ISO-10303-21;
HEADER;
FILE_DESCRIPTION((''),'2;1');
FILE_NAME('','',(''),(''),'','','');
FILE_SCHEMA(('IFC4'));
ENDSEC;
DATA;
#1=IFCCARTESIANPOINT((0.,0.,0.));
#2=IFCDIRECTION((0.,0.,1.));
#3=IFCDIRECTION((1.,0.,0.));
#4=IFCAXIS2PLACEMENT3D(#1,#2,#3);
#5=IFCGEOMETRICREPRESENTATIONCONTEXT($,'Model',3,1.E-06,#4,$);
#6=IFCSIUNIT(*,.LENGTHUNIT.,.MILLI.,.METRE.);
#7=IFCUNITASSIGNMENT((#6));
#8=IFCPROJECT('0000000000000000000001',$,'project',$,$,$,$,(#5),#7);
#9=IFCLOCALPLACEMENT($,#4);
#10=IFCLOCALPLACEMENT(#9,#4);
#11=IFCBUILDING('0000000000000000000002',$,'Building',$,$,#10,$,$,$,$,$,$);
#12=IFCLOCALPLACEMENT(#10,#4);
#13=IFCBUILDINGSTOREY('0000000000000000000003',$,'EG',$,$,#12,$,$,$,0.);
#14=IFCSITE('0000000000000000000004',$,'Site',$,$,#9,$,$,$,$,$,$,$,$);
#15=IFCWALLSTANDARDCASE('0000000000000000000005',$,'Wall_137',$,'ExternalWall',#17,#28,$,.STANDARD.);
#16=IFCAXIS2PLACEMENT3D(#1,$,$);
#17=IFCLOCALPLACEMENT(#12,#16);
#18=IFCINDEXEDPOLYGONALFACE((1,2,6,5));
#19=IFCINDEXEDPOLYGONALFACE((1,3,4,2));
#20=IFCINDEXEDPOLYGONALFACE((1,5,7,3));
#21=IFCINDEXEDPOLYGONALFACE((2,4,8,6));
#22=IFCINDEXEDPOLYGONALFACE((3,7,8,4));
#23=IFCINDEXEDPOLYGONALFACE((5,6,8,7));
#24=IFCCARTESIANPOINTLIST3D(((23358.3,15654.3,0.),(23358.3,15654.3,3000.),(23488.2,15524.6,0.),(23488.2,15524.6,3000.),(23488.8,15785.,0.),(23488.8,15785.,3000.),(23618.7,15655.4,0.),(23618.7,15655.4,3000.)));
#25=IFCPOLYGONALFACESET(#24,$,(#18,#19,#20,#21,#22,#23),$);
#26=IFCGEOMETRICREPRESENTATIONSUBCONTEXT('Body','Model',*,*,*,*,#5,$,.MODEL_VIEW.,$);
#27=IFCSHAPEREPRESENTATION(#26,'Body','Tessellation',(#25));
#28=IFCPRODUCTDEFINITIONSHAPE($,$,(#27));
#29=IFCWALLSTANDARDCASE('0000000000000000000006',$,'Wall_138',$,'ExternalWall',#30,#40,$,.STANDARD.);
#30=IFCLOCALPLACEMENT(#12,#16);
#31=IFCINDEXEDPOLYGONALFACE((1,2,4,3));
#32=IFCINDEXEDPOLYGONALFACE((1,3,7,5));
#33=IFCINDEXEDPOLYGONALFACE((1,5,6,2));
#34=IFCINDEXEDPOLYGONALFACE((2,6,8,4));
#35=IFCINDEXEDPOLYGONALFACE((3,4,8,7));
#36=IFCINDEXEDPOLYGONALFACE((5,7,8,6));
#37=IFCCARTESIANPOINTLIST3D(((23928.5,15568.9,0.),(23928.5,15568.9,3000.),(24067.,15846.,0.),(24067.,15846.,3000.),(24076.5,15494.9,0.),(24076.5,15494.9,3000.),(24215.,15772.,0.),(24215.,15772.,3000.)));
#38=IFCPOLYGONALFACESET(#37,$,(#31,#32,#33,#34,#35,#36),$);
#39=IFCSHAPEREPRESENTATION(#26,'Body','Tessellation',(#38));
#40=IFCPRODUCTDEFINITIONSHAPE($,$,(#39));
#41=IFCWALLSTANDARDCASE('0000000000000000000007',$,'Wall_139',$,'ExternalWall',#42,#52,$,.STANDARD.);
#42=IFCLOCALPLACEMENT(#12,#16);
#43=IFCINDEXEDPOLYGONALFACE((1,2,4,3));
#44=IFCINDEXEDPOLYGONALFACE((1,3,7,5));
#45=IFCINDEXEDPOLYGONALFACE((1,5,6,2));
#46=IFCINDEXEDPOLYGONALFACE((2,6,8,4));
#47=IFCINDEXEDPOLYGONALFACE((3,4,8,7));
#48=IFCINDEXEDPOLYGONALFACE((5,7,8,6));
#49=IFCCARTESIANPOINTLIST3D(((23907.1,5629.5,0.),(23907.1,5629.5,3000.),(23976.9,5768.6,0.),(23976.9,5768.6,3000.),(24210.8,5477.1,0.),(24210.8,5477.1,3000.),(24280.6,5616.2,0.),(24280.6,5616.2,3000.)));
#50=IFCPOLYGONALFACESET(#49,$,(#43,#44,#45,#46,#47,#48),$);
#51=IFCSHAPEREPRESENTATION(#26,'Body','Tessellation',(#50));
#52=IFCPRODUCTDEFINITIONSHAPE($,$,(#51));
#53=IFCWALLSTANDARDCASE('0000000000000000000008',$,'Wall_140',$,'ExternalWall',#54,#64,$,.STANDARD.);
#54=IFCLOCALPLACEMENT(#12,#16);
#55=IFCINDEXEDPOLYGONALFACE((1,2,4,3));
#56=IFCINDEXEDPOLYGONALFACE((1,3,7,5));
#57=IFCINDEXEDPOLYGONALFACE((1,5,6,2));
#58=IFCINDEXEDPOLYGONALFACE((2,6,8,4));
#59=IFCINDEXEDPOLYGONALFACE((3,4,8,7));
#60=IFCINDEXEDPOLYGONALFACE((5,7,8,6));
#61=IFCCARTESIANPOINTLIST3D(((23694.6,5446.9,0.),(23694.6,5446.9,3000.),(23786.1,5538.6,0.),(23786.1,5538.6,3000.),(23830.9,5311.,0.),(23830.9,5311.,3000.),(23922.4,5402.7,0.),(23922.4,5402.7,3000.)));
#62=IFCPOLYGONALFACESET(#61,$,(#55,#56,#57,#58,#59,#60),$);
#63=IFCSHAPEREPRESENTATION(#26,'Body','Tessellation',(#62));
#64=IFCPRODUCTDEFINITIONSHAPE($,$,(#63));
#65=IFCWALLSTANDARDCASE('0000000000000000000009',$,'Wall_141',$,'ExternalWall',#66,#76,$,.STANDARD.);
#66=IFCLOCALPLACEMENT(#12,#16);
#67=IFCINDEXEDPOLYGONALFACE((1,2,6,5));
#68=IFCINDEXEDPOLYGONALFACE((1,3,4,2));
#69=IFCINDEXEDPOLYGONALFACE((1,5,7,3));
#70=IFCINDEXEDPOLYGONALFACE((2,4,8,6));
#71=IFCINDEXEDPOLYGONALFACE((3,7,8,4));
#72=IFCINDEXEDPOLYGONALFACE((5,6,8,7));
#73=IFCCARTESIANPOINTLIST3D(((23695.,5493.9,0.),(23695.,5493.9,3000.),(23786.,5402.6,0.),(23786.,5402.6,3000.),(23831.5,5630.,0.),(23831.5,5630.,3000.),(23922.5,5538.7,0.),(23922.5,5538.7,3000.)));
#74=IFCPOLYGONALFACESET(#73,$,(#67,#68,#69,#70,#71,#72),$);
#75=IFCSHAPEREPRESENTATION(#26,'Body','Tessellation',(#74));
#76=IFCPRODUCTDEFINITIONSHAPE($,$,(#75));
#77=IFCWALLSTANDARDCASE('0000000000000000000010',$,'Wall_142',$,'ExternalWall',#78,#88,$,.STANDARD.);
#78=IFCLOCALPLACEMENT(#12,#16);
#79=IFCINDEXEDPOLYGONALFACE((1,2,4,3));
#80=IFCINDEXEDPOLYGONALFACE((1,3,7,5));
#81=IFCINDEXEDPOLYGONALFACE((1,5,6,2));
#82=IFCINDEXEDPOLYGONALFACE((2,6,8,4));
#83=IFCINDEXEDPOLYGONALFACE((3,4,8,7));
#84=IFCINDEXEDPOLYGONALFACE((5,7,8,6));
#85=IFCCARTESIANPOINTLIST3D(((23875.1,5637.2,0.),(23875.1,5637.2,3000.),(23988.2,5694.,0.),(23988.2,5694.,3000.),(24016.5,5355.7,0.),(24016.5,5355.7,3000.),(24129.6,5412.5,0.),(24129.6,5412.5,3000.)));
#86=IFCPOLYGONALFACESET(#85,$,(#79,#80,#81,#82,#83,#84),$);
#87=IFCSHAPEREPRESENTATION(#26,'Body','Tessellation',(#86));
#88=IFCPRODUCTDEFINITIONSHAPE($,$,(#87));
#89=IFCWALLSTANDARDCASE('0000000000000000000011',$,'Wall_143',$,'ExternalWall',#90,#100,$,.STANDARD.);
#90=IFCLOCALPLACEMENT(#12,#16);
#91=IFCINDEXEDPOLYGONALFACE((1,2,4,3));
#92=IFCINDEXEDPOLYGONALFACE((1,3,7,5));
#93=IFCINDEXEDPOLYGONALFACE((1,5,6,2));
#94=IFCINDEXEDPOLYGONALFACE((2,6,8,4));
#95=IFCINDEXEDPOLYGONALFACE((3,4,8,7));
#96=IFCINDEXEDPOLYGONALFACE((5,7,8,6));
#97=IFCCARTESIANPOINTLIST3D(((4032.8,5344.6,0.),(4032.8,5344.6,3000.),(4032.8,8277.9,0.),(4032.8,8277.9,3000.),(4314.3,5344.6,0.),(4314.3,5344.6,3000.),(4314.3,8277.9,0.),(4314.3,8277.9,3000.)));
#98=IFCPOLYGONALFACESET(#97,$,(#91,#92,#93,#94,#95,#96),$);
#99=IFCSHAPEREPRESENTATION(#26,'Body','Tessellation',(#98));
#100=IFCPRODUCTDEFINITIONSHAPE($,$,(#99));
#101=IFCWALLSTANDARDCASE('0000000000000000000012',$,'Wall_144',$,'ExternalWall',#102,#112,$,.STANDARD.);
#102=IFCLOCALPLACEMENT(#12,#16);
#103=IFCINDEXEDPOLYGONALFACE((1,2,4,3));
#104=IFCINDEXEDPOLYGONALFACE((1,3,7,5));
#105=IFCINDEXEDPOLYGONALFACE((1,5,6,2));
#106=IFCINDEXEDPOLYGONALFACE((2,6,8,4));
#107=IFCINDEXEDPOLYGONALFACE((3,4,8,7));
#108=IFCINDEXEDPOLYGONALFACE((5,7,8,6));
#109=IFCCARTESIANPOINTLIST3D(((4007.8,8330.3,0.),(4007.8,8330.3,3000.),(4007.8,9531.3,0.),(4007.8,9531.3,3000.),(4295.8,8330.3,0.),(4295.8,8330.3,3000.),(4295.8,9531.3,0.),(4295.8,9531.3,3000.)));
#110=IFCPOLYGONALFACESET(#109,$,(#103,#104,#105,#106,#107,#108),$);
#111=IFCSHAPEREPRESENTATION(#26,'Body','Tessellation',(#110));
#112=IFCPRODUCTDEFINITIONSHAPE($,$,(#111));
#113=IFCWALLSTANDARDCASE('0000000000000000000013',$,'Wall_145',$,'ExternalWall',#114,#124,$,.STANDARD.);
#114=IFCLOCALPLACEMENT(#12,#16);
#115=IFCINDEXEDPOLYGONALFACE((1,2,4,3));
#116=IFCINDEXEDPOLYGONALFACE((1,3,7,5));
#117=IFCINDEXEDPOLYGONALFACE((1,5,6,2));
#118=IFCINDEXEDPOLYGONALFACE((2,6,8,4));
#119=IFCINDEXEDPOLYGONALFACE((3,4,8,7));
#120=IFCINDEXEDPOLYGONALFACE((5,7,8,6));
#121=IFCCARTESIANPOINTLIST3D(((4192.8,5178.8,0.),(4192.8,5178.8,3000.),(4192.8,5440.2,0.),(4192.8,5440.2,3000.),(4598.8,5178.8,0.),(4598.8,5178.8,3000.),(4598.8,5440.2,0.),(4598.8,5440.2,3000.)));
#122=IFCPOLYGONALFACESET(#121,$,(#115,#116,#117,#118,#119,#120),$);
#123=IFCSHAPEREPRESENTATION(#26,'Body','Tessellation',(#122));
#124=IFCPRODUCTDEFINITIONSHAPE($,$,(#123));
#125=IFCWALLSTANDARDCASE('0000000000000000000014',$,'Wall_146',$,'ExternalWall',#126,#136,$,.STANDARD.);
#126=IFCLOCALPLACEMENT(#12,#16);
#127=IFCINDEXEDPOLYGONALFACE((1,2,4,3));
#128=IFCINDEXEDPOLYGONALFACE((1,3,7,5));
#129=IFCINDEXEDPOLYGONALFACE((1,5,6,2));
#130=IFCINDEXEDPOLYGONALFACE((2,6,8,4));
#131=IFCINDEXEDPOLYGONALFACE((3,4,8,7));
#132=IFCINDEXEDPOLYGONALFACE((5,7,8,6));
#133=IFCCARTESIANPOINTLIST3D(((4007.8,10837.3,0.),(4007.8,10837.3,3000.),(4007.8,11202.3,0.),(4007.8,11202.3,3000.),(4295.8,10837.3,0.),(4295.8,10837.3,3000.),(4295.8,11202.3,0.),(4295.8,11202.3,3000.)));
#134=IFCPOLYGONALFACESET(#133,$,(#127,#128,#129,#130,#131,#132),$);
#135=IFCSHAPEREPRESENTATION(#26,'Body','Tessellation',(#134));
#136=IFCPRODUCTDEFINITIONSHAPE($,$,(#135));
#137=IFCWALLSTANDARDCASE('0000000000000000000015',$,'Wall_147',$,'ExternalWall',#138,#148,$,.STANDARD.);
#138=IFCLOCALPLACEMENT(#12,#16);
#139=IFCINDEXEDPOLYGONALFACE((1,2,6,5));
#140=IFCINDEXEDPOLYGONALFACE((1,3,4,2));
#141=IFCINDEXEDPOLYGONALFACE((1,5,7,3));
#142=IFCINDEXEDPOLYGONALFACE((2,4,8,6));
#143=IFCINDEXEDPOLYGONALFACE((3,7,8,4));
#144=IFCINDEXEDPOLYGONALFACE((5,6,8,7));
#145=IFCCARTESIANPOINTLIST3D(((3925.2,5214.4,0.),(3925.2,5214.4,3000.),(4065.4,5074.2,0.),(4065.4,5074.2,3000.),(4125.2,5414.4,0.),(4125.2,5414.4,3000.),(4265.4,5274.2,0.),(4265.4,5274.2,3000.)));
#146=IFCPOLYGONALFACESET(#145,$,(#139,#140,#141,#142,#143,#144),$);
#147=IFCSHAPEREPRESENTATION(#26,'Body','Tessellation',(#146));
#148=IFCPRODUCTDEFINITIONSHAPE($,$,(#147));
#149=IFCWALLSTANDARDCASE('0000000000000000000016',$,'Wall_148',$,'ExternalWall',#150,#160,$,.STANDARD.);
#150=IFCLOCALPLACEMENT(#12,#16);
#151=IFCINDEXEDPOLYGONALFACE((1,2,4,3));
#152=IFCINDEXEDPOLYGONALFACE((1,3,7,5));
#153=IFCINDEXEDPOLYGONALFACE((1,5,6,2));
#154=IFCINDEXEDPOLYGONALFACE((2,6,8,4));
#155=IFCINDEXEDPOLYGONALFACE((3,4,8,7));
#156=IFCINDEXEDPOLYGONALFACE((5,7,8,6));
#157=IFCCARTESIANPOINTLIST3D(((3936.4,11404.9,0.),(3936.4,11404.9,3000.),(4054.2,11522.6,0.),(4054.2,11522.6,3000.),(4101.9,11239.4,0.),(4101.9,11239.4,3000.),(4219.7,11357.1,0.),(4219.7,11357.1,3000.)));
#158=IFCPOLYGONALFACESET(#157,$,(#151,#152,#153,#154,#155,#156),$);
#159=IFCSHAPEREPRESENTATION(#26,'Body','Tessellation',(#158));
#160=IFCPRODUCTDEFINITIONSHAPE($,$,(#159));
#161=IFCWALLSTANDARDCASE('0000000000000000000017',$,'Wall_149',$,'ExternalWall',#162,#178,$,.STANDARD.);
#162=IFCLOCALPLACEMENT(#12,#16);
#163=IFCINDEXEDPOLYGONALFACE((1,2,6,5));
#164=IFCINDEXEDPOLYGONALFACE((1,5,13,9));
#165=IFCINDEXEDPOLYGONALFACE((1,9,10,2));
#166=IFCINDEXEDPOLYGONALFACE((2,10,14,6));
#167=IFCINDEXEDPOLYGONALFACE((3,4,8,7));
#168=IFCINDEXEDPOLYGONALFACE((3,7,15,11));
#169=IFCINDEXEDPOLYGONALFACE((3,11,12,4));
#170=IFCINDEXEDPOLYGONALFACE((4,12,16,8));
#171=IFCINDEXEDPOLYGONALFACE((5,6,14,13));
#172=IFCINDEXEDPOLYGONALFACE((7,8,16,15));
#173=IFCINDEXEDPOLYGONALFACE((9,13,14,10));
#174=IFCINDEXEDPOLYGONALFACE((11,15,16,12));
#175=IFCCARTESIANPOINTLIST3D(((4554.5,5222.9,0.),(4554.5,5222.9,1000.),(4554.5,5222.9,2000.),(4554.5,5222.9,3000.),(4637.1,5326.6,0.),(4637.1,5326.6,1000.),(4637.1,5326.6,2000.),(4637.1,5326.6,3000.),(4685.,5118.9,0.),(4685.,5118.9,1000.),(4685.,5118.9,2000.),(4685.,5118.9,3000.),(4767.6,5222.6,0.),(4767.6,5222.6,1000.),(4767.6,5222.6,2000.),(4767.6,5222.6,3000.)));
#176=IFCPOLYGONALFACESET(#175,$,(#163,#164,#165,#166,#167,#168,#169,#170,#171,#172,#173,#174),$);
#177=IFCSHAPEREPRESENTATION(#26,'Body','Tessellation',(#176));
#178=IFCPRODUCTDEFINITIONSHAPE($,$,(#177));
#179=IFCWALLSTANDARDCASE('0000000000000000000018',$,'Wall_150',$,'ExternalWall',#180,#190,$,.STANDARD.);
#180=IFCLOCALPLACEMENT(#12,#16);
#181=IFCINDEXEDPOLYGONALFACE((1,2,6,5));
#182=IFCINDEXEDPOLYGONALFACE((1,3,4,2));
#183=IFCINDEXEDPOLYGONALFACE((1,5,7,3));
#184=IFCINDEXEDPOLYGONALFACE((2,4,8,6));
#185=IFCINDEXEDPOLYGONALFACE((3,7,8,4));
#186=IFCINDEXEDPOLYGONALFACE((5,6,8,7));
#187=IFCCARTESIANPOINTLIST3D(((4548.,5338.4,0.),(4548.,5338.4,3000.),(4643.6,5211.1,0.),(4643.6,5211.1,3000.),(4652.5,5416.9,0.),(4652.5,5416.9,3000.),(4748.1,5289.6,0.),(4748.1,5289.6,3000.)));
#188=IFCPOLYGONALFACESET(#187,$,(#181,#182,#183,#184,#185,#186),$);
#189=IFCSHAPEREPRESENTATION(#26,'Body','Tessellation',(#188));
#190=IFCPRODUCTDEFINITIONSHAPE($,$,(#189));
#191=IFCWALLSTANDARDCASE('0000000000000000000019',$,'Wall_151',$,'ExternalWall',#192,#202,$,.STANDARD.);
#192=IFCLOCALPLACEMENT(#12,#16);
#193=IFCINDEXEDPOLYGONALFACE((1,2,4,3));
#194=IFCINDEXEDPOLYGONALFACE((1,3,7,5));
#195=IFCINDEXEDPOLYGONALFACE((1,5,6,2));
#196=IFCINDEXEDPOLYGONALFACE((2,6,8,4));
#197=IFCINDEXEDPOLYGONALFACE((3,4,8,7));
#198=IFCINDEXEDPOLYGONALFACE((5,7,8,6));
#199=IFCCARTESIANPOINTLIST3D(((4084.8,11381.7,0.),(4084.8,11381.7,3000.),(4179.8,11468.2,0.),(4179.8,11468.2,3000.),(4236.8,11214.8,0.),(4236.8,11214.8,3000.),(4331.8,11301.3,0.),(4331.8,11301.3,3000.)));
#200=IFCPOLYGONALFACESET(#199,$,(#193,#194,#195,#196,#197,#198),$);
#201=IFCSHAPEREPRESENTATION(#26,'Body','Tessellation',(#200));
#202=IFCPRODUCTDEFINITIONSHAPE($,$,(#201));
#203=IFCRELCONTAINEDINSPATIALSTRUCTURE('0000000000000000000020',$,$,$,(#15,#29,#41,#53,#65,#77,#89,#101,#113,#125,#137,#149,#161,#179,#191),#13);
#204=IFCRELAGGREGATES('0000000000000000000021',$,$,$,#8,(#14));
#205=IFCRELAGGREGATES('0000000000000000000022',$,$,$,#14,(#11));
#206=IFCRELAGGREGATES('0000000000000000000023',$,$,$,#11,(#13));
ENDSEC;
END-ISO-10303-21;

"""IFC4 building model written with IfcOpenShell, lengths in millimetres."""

from ifc_helpers import new_model, si_unit, frame, origin_with_axes, place, context, subcontext, project, spatial, rectangle, extrude, element, save


model = new_model("IFC4")

# Units and contexts
model_context = context("Model", 3, precision=1e-06, world=origin_with_axes())
body_context = subcontext(model_context, "Body", "Model", "MODEL_VIEW")
ifc_project = project(units=[si_unit("LENGTHUNIT", "METRE", prefix="MILLI")], contexts=[model_context])

# Site, building, storey
site_placement = place(None, origin_with_axes())
site = spatial("IfcSite", under=ifc_project, at=site_placement, Name="Site")
building_placement = place(site_placement, origin_with_axes())
building = spatial("IfcBuilding", under=site, at=building_placement, Name="Building")
storey_placement = place(building_placement, origin_with_axes())
storey = spatial("IfcBuildingStorey", under=building, at=storey_placement, Name="EG", Elevation=0.0)

# Walls
wall_1_placement = place(storey_placement, origin_with_axes())
element("IfcWallStandardCase", 1, at=wall_1_placement, inside=storey, Name="Wall_137", ObjectType="ExternalWall", PredefinedType="STANDARD", context=body_context, shape_type="SweptSolid", body=[
    extrude(rectangle(XDim=184.7, YDim=183.5), frame((23488.5, 15654.8, 0.0), z_axis=(0.0, 0.0, 1.0), x_axis=(-0.70643, -0.707783, 0.0)), (0.0, 0.0, 1.0), 3000.0),
])
wall_2_placement = place(storey_placement, origin_with_axes())
element("IfcWallStandardCase", 2, at=wall_2_placement, inside=storey, Name="Wall_138", ObjectType="ExternalWall", PredefinedType="STANDARD", context=body_context, shape_type="SweptSolid", body=[
    extrude(rectangle(XDim=165.5, YDim=309.9), frame((24071.8, 15670.4, 0.0), z_axis=(0.0, 0.0, 1.0), x_axis=(-0.894427, 0.447214, 0.0)), (0.0, 0.0, 1.0), 3000.0),
])
wall_3_placement = place(storey_placement, origin_with_axes())
element("IfcWallStandardCase", 3, at=wall_3_placement, inside=storey, Name="Wall_139", ObjectType="ExternalWall", PredefinedType="STANDARD", context=body_context, shape_type="SweptSolid", body=[
    extrude(rectangle(XDim=155.7, YDim=339.8), frame((24093.8, 5622.9, 0.0), z_axis=(0.0, 0.0, 1.0), x_axis=(-0.448498, -0.893784, 0.0)), (0.0, 0.0, 1.0), 3000.0),
])
wall_4_placement = place(storey_placement, origin_with_axes())
element("IfcWallStandardCase", 4, at=wall_4_placement, inside=storey, Name="Wall_140", ObjectType="ExternalWall", PredefinedType="STANDARD", context=body_context, shape_type="SweptSolid", body=[
    extrude(rectangle(XDim=129.6, YDim=192.4), frame((23808.5, 5424.8, 0.0), z_axis=(0.0, 0.0, 1.0), x_axis=(-0.706141, -0.708071, 0.0)), (0.0, 0.0, 1.0), 3000.0),
])
wall_5_placement = place(storey_placement, origin_with_axes())
element("IfcWallStandardCase", 5, at=wall_5_placement, inside=storey, Name="Wall_141", ObjectType="ExternalWall", PredefinedType="STANDARD", context=body_context, shape_type="SweptSolid", body=[
    extrude(rectangle(XDim=128.9, YDim=192.7), frame((23808.8, 5516.3, 0.0), z_axis=(0.0, 0.0, 1.0), x_axis=(-0.706136, 0.708076, 0.0)), (0.0, 0.0, 1.0), 3000.0),
])
wall_6_placement = place(storey_placement, origin_with_axes())
element("IfcWallStandardCase", 6, at=wall_6_placement, inside=storey, Name="Wall_142", ObjectType="ExternalWall", PredefinedType="STANDARD", context=body_context, shape_type="SweptSolid", body=[
    extrude(rectangle(XDim=126.6, YDim=315.1), frame((24002.3, 5524.9, 0.0), z_axis=(0.0, 0.0, 1.0), x_axis=(-0.893636, -0.448792, 0.0)), (0.0, 0.0, 1.0), 3000.0),
])
wall_7_placement = place(storey_placement, origin_with_axes())
element("IfcWallStandardCase", 7, at=wall_7_placement, inside=storey, Name="Wall_143", ObjectType="ExternalWall", PredefinedType="STANDARD", context=body_context, shape_type="SweptSolid", body=[
    extrude(rectangle(XDim=2933.3, YDim=281.4), frame((4173.5, 6811.3, 0.0), z_axis=(0.0, 0.0, 1.0), x_axis=(0.0, -1.0, 0.0)), (0.0, 0.0, 1.0), 3000.0),
])
wall_8_placement = place(storey_placement, origin_with_axes())
element("IfcWallStandardCase", 8, at=wall_8_placement, inside=storey, Name="Wall_144", ObjectType="ExternalWall", PredefinedType="STANDARD", context=body_context, shape_type="SweptSolid", body=[
    extrude(rectangle(XDim=1201.0, YDim=288.0), frame((4151.8, 8930.8, 0.0), z_axis=(0.0, 0.0, 1.0), x_axis=(0.0, -1.0, 0.0)), (0.0, 0.0, 1.0), 3000.0),
])
wall_9_placement = place(storey_placement, origin_with_axes())
element("IfcWallStandardCase", 9, at=wall_9_placement, inside=storey, Name="Wall_145", ObjectType="ExternalWall", PredefinedType="STANDARD", context=body_context, shape_type="SweptSolid", body=[
    extrude(rectangle(XDim=406.0, YDim=261.4), frame((4395.8, 5309.5, 0.0), z_axis=(0.0, 0.0, 1.0), x_axis=(1.0, 0.0, 0.0)), (0.0, 0.0, 1.0), 3000.0),
])
wall_10_placement = place(storey_placement, origin_with_axes())
element("IfcWallStandardCase", 10, at=wall_10_placement, inside=storey, Name="Wall_146", ObjectType="ExternalWall", PredefinedType="STANDARD", context=body_context, shape_type="SweptSolid", body=[
    extrude(rectangle(XDim=365.0, YDim=288.0), frame((4151.8, 11019.8, 0.0), z_axis=(0.0, 0.0, 1.0), x_axis=(0.0, 1.0, 0.0)), (0.0, 0.0, 1.0), 3000.0),
])
wall_11_placement = place(storey_placement, origin_with_axes())
element("IfcWallStandardCase", 11, at=wall_11_placement, inside=storey, Name="Wall_147", ObjectType="ExternalWall", PredefinedType="STANDARD", context=body_context, shape_type="SweptSolid", body=[
    extrude(rectangle(XDim=282.8, YDim=198.3), frame((4095.3, 5244.3, 0.0), z_axis=(0.0, 0.0, 1.0), x_axis=(-0.707107, -0.707107, 0.0)), (0.0, 0.0, 1.0), 3000.0),
])
wall_12_placement = place(storey_placement, origin_with_axes())
element("IfcWallStandardCase", 12, at=wall_12_placement, inside=storey, Name="Wall_148", ObjectType="ExternalWall", PredefinedType="STANDARD", context=body_context, shape_type="SweptSolid", body=[
    extrude(rectangle(XDim=234.1, YDim=166.5), frame((4078.0, 11381.0, 0.0), z_axis=(0.0, 0.0, 1.0), x_axis=(-0.707107, 0.707107, 0.0)), (0.0, 0.0, 1.0), 3000.0),
])

# Wall, opening
wall_13_placement = place(storey_placement, origin_with_axes())
wall_13 = element("IfcWallStandardCase", 13, at=wall_13_placement, inside=storey, Name="Wall_149", ObjectType="ExternalWall", PredefinedType="STANDARD", context=body_context, shape_type="SweptSolid", body=[
    extrude(rectangle(XDim=166.9, YDim=132.6), frame((4661.0, 5222.8, 0.0), z_axis=(0.0, 0.0, 1.0), x_axis=(0.782037, -0.623232, 0.0)), (0.0, 0.0, 1.0), 3000.0),
])
opening_1_placement = place(wall_13_placement, origin_with_axes())
element("IfcOpeningElement", 14, at=opening_1_placement, inside=storey, cuts=wall_13, context=body_context, shape_type="SweptSolid", body=[
    extrude(rectangle(XDim=600.0, YDim=132.6), frame((4677.1, 5209.9, 1000.0), z_axis=(0.0, 0.0, 1.0), x_axis=(0.782037, -0.623232, 0.0)), (0.0, 0.0, 1.0), 1000.0),
])

# Walls
wall_14_placement = place(storey_placement, origin_with_axes())
element("IfcWallStandardCase", 15, at=wall_14_placement, inside=storey, Name="Wall_150", ObjectType="ExternalWall", PredefinedType="STANDARD", context=body_context, shape_type="SweptSolid", body=[
    extrude(rectangle(XDim=130.7, YDim=159.3), frame((4648.0, 5314.0, 0.0), z_axis=(0.0, 0.0, 1.0), x_axis=(0.799541, 0.600612, 0.0)), (0.0, 0.0, 1.0), 3000.0),
])
wall_15_placement = place(storey_placement, origin_with_axes())
element("IfcWallStandardCase", 16, at=wall_15_placement, inside=storey, Name="Wall_151", ObjectType="ExternalWall", PredefinedType="STANDARD", context=body_context, shape_type="SweptSolid", body=[
    extrude(rectangle(XDim=128.5, YDim=225.8), frame((4208.3, 11341.5, 0.0), z_axis=(0.0, 0.0, 1.0), x_axis=(0.739412, 0.673254, 0.0)), (0.0, 0.0, 1.0), 3000.0),
])

save(model, "model.ifc")
